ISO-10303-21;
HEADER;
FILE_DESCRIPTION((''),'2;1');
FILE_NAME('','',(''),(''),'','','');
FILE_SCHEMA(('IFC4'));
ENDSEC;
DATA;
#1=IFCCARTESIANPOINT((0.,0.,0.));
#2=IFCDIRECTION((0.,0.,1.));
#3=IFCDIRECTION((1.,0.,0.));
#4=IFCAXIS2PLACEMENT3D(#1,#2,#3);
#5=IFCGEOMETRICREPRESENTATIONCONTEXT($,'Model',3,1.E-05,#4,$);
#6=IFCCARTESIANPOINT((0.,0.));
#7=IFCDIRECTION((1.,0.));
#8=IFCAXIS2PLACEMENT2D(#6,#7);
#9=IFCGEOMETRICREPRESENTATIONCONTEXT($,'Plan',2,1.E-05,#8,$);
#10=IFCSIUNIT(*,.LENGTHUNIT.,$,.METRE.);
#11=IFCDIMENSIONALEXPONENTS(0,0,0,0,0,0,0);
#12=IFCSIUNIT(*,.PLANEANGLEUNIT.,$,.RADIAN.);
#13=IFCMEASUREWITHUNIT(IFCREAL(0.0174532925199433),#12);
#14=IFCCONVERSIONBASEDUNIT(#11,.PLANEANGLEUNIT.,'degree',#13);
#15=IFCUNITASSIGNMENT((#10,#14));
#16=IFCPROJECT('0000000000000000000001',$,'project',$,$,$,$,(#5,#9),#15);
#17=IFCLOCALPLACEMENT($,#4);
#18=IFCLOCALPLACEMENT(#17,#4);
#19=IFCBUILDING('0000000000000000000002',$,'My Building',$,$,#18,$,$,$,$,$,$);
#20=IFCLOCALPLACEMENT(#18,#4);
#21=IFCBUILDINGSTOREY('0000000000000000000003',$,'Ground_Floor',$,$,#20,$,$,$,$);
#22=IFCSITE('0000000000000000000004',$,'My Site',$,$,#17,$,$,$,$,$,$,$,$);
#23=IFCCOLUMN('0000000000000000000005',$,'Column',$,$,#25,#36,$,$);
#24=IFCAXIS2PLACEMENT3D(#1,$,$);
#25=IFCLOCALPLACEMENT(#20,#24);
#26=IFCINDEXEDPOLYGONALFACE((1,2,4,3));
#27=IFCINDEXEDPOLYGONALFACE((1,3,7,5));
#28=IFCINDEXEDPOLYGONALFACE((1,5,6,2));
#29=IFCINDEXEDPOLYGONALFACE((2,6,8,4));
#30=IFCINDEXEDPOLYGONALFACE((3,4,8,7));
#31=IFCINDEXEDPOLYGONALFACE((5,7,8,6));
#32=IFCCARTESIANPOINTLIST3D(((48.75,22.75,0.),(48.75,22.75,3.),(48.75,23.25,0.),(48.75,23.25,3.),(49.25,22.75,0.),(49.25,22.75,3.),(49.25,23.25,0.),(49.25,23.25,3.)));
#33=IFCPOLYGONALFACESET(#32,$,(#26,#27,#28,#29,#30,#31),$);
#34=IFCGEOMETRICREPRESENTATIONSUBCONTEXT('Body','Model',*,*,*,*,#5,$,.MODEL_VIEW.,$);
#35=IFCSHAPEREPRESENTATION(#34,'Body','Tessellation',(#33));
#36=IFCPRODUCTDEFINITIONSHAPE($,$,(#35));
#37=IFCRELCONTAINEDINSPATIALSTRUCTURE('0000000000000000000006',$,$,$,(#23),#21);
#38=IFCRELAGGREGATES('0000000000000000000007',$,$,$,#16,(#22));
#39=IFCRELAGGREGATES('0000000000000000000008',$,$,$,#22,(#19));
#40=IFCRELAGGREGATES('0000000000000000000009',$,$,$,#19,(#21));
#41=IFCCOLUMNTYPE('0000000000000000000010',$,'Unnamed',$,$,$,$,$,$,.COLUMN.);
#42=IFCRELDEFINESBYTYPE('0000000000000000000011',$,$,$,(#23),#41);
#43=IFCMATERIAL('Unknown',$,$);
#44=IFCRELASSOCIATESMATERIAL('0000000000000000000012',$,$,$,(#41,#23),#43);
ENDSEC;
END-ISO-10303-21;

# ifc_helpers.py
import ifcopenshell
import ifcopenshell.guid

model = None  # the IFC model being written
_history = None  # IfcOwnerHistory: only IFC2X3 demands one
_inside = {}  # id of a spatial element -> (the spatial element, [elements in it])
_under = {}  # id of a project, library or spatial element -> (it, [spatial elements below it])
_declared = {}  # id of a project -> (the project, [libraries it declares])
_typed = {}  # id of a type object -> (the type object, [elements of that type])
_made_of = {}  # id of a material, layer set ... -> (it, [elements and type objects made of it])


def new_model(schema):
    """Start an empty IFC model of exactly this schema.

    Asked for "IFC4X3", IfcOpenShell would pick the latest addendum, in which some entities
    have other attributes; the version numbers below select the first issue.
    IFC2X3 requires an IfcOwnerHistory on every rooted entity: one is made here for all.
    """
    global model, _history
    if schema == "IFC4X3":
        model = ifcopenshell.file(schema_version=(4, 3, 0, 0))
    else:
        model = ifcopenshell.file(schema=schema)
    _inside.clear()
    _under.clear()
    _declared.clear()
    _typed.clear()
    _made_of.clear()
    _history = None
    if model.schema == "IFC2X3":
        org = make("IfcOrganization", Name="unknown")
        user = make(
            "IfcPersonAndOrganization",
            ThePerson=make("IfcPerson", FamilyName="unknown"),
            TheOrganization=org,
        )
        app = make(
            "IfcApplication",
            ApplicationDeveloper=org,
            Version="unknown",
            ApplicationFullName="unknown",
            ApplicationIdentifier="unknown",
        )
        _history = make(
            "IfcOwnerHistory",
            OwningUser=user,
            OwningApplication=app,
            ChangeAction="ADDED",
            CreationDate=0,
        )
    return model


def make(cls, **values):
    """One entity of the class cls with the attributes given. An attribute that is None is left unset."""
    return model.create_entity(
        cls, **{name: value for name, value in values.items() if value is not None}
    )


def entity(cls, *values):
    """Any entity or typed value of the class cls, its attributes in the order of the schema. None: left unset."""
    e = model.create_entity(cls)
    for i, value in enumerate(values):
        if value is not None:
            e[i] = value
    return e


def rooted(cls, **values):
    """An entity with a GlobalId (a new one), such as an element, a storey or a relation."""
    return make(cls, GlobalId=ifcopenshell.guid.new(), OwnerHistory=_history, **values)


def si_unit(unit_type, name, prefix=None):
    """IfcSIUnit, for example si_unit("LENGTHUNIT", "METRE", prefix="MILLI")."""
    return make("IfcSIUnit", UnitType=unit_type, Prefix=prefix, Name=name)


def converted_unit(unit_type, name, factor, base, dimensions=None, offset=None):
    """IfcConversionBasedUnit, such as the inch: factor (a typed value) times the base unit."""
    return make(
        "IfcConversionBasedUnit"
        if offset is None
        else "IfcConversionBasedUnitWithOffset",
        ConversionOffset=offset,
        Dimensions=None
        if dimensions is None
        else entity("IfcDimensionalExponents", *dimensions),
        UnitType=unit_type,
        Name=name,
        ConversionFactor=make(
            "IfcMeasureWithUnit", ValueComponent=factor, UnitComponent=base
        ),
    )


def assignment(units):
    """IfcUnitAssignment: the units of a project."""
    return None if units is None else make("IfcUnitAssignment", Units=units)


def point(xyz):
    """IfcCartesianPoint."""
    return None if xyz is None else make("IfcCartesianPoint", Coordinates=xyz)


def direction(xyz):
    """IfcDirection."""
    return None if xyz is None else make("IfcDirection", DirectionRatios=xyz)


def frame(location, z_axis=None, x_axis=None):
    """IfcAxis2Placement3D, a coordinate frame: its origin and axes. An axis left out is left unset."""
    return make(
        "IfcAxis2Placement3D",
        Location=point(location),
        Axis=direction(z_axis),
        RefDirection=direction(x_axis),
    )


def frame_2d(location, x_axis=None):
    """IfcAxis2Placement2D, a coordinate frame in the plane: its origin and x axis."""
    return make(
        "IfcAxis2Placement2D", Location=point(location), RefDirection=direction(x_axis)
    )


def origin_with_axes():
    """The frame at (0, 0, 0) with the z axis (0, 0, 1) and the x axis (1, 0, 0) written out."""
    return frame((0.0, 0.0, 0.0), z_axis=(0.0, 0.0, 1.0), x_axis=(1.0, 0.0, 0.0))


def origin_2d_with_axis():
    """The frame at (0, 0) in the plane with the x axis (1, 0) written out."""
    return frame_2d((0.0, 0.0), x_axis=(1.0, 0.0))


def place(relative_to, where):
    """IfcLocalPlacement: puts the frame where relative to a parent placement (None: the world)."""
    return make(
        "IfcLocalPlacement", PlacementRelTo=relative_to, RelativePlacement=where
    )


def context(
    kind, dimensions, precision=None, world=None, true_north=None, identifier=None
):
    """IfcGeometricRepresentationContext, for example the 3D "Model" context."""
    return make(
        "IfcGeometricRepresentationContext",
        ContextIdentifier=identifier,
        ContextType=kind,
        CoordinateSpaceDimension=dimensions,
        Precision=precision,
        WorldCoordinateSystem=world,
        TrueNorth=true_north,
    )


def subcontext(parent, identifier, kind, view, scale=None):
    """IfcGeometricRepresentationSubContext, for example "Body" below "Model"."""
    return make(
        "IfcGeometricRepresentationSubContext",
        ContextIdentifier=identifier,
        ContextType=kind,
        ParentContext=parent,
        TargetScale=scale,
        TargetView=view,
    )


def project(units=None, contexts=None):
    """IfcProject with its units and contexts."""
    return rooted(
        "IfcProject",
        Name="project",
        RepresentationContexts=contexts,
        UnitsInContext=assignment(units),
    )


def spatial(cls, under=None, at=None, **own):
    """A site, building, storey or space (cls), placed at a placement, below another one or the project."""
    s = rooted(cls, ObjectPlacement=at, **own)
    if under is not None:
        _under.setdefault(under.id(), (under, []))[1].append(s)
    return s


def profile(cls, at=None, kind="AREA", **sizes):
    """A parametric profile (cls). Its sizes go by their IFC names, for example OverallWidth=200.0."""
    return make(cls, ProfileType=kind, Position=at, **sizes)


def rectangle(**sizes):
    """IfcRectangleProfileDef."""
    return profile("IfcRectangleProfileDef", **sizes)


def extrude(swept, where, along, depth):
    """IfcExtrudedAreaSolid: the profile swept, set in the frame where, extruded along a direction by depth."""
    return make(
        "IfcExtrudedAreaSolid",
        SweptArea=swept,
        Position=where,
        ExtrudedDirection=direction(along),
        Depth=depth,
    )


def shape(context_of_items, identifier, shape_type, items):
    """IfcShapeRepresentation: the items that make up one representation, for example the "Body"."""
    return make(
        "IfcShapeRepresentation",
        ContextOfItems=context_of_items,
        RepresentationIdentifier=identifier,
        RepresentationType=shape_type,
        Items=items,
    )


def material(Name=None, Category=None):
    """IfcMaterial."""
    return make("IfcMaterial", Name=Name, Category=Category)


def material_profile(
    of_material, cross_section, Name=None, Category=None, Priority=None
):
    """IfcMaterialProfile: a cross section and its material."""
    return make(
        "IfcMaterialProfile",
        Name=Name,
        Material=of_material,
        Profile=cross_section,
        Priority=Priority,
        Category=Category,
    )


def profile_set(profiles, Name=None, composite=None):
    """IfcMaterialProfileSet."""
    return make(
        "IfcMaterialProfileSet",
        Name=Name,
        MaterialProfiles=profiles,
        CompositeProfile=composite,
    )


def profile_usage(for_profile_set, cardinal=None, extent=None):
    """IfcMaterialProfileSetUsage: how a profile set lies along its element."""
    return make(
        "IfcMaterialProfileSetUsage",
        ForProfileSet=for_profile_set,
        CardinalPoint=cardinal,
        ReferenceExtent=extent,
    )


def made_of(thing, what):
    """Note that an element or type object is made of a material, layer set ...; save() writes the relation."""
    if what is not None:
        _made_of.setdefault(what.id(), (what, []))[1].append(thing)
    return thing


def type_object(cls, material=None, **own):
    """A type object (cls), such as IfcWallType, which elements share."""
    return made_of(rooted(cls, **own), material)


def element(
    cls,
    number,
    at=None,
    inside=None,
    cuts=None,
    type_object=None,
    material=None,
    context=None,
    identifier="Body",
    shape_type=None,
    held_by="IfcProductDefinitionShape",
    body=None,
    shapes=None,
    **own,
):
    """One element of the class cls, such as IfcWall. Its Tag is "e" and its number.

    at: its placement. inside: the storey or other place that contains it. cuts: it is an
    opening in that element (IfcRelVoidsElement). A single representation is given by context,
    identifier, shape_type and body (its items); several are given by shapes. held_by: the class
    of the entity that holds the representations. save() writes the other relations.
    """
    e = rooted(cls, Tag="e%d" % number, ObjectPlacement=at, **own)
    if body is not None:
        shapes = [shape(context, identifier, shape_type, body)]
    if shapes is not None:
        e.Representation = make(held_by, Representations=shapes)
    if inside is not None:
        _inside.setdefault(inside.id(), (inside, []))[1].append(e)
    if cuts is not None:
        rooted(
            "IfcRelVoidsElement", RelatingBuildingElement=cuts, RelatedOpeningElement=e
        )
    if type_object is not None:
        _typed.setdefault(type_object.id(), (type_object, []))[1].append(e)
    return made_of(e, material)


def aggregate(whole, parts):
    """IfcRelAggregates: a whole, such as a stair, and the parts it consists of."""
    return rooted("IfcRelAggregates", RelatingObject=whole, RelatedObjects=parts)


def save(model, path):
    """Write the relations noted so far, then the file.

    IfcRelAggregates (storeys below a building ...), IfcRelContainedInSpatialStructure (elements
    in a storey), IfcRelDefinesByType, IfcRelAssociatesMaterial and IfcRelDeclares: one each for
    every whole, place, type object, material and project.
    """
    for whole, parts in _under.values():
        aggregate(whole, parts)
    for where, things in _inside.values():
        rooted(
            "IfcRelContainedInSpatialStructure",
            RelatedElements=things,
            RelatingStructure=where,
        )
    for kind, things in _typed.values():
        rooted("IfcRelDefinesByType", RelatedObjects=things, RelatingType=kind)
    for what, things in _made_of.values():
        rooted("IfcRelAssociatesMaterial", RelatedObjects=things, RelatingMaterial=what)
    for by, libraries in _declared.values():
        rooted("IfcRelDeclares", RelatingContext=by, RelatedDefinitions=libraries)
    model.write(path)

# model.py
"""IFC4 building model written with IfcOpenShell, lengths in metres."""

from ifc_helpers import new_model, entity, si_unit, converted_unit, frame, origin_with_axes, origin_2d_with_axis, place, context, subcontext, project, spatial, rectangle, extrude, material, material_profile, profile_set, profile_usage, type_object, element, save


model = new_model("IFC4")

# Units and contexts
model_context = context("Model", 3, precision=1e-05, world=origin_with_axes())
plan_context = context("Plan", 2, precision=1e-05, world=origin_2d_with_axis())
body_context_1 = subcontext(model_context, "Body", "Model", "MODEL_VIEW")
ifc_project = project(units=[si_unit("LENGTHUNIT", "METRE"), converted_unit("PLANEANGLEUNIT", "degree", entity("IfcReal", 0.0174532925199433), si_unit("PLANEANGLEUNIT", "RADIAN"), dimensions=[0, 0, 0, 0, 0, 0, 0])], contexts=[model_context, plan_context])

# Site, building, storey
site_placement = place(None, origin_with_axes())
site = spatial("IfcSite", under=ifc_project, at=site_placement, Name="My Site")
building_placement = place(site_placement, origin_with_axes())
building = spatial("IfcBuilding", under=site, at=building_placement, Name="My Building")
storey_placement = place(building_placement, origin_with_axes())
storey = spatial("IfcBuildingStorey", under=building, at=storey_placement, Name="Ground_Floor")

# Column
ifc_material = material(Name="Unknown")
ifc_material_profile = material_profile(ifc_material, rectangle(XDim=0.5, YDim=0.5))
ifc_profile_set = profile_set([ifc_material_profile])
ifc_profile_usage = profile_usage(ifc_profile_set, cardinal=5)
column_type = type_object("IfcColumnType", Name="Unnamed", PredefinedType="COLUMN", material=ifc_profile_set)
column_placement = place(storey_placement, frame((49.0, 23.0, 0.0), z_axis=(0.0, 0.0, 1.0), x_axis=(1.0, 0.0, 0.0)))
element("IfcColumn", 1, at=column_placement, inside=storey, type_object=column_type, material=ifc_profile_usage, Name="Column", context=body_context_1, shape_type="SweptSolid", body=[
    extrude(rectangle(XDim=0.5, YDim=0.5), origin_with_axes(), (0.0, 0.0, 1.0), 3.0),
])

save(model, "model.ifc")
